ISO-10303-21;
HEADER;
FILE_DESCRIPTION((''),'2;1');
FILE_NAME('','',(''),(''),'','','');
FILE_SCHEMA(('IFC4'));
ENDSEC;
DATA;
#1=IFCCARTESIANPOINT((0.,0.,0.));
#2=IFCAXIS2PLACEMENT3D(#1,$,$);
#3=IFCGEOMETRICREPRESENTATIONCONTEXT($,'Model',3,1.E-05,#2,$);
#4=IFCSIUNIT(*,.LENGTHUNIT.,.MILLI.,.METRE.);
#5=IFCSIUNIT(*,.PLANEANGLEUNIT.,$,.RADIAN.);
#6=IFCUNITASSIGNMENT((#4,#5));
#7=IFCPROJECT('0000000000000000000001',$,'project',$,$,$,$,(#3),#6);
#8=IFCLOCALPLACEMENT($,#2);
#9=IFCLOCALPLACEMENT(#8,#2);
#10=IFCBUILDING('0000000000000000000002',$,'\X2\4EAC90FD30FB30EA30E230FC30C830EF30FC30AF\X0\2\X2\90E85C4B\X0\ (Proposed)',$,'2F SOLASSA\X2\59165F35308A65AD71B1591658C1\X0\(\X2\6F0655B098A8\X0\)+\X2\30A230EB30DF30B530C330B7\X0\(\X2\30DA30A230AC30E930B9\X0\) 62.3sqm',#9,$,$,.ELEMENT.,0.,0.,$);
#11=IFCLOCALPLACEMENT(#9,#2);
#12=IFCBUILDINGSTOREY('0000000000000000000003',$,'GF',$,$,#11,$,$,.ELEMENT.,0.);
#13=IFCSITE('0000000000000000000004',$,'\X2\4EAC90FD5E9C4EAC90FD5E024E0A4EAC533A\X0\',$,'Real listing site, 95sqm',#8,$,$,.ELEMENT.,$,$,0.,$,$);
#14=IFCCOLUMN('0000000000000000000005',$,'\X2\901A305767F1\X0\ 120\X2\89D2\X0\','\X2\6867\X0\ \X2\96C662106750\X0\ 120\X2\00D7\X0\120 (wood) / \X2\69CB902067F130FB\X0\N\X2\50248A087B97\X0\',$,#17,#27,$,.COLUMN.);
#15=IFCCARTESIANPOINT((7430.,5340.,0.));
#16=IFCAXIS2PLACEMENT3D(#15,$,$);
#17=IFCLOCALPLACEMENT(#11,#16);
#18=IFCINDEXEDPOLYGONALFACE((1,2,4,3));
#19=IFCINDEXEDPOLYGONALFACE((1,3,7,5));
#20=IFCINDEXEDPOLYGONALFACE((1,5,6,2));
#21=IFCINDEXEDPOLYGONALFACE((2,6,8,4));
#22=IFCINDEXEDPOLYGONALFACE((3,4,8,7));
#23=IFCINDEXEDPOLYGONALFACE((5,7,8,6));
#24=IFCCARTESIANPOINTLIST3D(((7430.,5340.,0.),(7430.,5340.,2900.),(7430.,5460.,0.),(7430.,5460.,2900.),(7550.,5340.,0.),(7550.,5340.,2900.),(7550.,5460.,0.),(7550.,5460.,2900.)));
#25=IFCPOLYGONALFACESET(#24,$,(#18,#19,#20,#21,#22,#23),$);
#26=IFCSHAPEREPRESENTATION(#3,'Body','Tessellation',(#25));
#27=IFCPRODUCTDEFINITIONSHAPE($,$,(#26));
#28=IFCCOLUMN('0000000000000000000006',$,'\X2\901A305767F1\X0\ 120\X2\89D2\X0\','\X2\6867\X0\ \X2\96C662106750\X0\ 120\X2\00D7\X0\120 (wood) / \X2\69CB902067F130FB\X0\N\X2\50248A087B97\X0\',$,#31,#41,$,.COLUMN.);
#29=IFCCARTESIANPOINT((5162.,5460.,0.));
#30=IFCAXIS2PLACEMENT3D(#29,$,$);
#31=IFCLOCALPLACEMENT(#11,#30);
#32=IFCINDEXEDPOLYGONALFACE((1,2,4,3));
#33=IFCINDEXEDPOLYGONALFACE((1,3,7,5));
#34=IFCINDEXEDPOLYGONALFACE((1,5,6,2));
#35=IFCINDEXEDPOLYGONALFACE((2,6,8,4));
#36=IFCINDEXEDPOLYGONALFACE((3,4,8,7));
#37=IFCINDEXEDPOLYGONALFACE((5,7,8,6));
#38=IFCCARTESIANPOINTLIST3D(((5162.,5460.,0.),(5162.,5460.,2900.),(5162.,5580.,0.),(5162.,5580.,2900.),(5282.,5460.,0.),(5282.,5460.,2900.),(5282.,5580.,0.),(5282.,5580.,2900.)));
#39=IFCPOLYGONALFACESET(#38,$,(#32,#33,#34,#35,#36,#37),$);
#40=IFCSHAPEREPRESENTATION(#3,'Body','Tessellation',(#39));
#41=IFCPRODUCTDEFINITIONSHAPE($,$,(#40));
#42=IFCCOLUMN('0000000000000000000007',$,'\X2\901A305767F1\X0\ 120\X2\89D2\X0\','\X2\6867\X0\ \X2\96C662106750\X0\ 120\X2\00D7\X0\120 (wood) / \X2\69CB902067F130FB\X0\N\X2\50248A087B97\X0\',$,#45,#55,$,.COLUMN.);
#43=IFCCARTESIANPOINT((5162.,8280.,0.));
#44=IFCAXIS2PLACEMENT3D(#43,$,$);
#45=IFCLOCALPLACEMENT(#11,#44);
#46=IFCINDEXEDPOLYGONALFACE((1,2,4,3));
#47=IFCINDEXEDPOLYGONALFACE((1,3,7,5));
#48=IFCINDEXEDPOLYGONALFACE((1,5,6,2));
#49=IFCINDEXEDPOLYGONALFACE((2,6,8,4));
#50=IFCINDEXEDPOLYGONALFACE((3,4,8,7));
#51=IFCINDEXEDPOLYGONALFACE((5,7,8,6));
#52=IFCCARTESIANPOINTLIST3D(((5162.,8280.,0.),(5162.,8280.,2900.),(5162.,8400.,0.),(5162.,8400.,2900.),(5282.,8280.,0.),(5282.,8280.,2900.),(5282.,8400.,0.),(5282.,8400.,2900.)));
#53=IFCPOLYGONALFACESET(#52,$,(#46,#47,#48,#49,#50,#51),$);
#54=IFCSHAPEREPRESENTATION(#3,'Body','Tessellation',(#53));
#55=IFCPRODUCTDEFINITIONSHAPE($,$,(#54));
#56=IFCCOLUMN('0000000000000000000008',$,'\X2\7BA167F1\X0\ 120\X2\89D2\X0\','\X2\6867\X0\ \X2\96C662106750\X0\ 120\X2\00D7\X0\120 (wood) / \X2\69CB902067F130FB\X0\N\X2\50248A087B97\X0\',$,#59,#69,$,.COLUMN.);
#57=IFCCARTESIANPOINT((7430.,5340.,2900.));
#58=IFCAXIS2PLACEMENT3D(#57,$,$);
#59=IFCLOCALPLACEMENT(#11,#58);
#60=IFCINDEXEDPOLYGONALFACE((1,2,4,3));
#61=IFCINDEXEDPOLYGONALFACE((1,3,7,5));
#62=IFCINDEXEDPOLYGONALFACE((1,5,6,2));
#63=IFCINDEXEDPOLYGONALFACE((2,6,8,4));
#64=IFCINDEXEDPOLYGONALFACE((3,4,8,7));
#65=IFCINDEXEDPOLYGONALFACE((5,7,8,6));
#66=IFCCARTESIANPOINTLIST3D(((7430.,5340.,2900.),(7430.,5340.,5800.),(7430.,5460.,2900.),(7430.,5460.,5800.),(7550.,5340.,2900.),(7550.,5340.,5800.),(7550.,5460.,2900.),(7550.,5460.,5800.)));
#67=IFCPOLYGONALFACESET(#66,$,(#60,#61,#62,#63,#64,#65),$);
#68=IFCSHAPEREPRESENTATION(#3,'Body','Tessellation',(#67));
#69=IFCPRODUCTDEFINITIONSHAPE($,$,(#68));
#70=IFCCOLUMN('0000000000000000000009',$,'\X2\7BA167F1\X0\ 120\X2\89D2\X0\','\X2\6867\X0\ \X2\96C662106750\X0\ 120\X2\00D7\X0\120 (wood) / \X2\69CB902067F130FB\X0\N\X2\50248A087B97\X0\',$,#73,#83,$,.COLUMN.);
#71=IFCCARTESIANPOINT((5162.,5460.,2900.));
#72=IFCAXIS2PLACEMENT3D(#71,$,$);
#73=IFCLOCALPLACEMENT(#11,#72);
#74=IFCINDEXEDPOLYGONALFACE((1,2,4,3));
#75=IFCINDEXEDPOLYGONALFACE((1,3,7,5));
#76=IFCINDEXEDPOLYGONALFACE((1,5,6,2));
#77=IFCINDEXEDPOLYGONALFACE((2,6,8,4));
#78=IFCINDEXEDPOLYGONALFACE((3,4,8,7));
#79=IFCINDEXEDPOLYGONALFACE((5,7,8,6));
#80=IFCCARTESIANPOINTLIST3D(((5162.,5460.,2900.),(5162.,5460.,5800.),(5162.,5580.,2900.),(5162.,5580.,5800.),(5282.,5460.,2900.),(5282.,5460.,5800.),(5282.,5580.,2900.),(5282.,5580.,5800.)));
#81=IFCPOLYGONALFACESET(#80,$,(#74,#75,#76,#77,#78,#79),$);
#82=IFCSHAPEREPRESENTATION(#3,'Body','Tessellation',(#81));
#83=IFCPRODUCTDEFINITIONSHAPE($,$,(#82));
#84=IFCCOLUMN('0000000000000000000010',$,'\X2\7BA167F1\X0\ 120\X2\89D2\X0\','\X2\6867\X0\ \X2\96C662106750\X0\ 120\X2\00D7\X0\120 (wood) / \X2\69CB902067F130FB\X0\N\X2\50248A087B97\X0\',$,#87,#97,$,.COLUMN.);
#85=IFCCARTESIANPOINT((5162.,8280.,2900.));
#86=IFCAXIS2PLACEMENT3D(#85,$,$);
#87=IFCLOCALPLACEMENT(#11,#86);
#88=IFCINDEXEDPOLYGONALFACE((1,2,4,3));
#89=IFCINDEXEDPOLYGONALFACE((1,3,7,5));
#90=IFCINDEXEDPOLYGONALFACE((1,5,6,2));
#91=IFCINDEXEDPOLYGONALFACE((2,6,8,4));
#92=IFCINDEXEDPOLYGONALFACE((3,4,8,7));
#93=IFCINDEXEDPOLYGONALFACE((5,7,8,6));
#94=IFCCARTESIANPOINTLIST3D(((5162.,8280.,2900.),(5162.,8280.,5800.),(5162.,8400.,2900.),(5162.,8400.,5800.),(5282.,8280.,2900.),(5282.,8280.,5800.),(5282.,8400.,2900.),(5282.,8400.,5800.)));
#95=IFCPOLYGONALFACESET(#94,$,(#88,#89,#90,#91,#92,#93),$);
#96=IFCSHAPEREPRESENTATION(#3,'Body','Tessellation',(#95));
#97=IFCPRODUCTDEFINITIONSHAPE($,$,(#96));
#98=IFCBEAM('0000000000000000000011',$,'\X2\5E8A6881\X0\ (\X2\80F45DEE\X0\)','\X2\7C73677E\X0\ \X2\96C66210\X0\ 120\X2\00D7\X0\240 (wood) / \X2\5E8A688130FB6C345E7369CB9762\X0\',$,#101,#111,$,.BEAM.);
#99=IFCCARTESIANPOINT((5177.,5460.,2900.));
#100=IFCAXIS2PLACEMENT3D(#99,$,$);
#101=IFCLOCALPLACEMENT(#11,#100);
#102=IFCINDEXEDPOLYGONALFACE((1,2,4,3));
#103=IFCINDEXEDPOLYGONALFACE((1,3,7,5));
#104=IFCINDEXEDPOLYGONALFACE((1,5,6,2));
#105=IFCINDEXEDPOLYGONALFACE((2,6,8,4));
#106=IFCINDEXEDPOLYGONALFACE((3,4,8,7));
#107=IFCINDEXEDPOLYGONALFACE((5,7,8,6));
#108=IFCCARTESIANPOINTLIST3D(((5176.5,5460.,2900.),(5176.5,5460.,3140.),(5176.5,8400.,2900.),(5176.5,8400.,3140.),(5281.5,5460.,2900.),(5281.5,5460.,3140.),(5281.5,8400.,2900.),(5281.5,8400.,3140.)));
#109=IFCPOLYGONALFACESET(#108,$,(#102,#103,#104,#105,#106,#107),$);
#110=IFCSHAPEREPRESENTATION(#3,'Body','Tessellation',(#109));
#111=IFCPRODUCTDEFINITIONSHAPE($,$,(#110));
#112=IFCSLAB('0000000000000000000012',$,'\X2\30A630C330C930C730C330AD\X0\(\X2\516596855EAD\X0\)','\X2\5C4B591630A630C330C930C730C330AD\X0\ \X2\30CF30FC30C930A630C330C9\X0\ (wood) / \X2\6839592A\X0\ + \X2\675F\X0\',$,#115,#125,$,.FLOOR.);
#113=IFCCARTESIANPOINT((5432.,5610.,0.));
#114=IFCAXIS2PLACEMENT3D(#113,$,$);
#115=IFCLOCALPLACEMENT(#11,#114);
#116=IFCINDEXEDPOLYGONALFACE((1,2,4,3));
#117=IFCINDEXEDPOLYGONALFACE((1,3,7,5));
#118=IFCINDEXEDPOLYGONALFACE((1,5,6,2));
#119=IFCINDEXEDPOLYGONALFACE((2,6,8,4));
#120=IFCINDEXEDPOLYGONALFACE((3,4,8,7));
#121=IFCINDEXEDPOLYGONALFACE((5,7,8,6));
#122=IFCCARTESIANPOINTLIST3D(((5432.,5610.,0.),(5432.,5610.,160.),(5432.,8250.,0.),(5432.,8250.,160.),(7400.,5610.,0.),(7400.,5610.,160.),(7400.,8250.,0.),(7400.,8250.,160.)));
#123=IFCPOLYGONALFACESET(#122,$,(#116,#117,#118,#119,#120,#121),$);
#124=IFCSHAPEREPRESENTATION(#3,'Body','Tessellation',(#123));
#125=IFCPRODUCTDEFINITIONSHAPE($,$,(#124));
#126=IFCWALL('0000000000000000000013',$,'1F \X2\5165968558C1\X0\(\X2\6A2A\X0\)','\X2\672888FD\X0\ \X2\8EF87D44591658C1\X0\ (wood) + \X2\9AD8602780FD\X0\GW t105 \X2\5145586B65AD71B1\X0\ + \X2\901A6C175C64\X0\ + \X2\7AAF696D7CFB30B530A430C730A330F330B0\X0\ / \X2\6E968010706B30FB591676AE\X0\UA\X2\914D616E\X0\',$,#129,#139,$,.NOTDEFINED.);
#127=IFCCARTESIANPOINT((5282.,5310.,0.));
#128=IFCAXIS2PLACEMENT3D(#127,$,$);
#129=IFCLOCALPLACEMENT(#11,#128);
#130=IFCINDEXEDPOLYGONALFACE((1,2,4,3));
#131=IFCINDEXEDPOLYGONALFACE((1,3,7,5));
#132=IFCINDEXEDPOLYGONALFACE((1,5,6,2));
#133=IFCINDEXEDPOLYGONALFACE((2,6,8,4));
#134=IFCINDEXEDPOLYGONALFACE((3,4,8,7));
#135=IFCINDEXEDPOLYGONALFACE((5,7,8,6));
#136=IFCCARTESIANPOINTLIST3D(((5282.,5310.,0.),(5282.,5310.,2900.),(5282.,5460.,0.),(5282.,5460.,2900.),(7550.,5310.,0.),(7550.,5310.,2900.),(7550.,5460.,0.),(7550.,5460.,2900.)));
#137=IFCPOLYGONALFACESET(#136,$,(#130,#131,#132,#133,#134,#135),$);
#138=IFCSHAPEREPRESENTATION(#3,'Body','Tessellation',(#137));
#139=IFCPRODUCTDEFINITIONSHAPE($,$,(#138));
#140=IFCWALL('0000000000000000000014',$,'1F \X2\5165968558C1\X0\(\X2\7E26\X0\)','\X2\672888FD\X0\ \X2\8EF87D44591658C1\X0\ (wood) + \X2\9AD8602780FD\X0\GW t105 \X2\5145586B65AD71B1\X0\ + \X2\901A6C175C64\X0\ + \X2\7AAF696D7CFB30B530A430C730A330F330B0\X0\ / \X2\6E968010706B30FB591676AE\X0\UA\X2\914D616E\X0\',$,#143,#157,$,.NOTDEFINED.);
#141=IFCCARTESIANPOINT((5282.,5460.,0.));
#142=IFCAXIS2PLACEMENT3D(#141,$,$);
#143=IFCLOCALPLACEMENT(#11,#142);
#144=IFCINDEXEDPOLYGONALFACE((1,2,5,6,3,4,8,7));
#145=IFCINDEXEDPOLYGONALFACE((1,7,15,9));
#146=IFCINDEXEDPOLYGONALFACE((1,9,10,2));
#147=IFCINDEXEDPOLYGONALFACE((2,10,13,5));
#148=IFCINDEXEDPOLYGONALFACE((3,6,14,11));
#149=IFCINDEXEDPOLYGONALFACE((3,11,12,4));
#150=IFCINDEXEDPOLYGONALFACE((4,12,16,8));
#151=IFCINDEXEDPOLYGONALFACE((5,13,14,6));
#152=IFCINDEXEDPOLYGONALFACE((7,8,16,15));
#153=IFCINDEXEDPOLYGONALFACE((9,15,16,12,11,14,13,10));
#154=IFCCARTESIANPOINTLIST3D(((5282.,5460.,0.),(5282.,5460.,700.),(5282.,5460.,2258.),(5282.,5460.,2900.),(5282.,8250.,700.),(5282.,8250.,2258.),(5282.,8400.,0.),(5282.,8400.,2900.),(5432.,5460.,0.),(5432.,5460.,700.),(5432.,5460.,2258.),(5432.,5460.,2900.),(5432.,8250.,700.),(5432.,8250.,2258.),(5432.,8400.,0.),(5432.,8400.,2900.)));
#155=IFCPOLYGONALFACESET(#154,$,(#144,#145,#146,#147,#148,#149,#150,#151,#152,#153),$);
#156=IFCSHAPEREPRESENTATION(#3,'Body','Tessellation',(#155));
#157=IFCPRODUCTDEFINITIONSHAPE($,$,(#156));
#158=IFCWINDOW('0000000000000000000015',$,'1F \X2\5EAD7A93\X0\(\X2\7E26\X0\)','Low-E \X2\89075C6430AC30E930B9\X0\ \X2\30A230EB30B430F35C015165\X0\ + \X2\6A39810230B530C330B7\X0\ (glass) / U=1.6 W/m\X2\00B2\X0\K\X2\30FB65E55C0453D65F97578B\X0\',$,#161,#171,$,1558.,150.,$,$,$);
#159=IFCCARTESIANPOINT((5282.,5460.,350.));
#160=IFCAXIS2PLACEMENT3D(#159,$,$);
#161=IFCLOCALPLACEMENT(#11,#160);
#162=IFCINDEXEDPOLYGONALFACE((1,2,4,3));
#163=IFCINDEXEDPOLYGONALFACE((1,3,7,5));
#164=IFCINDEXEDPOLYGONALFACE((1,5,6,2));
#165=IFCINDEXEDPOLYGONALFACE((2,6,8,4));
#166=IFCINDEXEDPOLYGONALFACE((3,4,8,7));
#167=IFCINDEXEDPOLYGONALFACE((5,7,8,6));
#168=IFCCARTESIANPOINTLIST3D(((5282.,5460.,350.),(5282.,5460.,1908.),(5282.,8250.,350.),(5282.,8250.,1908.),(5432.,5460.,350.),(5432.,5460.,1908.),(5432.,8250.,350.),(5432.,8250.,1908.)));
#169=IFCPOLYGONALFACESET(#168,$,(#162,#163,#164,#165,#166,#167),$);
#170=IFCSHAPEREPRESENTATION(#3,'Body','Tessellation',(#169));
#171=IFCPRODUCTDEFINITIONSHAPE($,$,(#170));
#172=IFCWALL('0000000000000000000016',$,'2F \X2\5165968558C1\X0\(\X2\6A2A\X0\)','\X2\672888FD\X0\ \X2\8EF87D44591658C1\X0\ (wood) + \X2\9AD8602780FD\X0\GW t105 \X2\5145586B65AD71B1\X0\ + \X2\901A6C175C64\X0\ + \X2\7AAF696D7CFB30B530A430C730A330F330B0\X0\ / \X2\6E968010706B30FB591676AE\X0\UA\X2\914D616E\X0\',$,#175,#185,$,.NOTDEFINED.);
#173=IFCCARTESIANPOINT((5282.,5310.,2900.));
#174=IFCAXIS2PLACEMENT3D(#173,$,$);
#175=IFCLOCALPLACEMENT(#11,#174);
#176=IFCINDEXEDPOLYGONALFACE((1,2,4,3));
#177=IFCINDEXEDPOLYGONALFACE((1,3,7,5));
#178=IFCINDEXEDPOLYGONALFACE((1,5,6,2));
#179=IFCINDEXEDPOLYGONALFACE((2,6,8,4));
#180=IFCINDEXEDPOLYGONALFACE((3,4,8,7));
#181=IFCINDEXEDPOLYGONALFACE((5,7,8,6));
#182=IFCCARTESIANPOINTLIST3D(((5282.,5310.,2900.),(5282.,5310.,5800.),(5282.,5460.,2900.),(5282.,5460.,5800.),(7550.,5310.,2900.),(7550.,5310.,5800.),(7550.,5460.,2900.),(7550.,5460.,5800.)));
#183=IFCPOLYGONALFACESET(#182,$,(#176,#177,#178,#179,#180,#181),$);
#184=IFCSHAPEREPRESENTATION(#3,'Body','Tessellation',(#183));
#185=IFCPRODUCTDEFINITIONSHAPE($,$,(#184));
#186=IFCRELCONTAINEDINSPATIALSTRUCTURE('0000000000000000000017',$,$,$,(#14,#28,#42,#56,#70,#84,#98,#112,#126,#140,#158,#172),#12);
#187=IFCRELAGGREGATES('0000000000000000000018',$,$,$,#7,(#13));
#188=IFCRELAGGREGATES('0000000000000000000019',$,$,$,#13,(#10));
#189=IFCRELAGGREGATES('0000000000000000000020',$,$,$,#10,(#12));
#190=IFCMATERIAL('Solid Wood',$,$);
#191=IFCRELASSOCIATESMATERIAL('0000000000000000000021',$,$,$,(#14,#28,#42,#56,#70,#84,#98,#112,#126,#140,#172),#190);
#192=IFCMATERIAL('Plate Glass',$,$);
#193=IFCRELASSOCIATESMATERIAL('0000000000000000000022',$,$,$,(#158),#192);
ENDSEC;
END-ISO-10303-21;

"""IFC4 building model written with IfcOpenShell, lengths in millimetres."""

from ifc_helpers import new_model, si_unit, frame, frame_2d, origin, place, context, project, spatial, rectangle, extrude, material, element, fill, save


model = new_model("IFC4")

# Units and contexts
model_context = context("Model", 3, precision=1e-05, world=origin())
ifc_project = project(units=[si_unit("LENGTHUNIT", "METRE", prefix="MILLI"), si_unit("PLANEANGLEUNIT", "RADIAN")], contexts=[model_context])

# Site, building, storey
site_placement = place(None, origin())
site = spatial("IfcSite", under=ifc_project, at=site_placement, Name="京都府京都市上京区", ObjectType="Real listing site, 95sqm", CompositionType="ELEMENT", RefElevation=0.0)
building_placement = place(site_placement, origin())
building = spatial("IfcBuilding", under=site, at=building_placement, Name="京都・リモートワーク2部屋 (Proposed)", ObjectType="2F SOLASSA外張り断熱外壁(漆喰風)+アルミサッシ(ペアガラス) 62.3sqm", CompositionType="ELEMENT", ElevationOfRefHeight=0.0, ElevationOfTerrain=0.0)
storey_placement = place(building_placement, origin())
storey = spatial("IfcBuildingStorey", under=building, at=storey_placement, Name="GF", CompositionType="ELEMENT", Elevation=0.0)

# Columns
ifc_material_1 = material(Name="Solid Wood")
column_1_placement = place(storey_placement, frame((7430.0, 5340.0, 0.0)))
element("IfcColumn", 1, at=column_1_placement, inside=storey, material=ifc_material_1, Name="通し柱 120角", Description="桧 集成材 120×120 (wood) / 構造柱・N値計算", PredefinedType="COLUMN", context=model_context, shape_type="SweptSolid", body=[
    extrude(rectangle(XDim=120.0, YDim=120.0, at=frame_2d((60.0, 60.0))), frame((7430.0, 5340.0, 0.0)), (0.0, 0.0, 1.0), 2900.0),
])
column_2_placement = place(storey_placement, frame((5162.0, 5460.0, 0.0)))
element("IfcColumn", 2, at=column_2_placement, inside=storey, material=ifc_material_1, Name="通し柱 120角", Description="桧 集成材 120×120 (wood) / 構造柱・N値計算", PredefinedType="COLUMN", context=model_context, shape_type="SweptSolid", body=[
    extrude(rectangle(XDim=120.0, YDim=120.0, at=frame_2d((60.0, 60.0))), frame((5162.0, 5460.0, 0.0)), (0.0, 0.0, 1.0), 2900.0),
])
column_3_placement = place(storey_placement, frame((5162.0, 8280.0, 0.0)))
element("IfcColumn", 3, at=column_3_placement, inside=storey, material=ifc_material_1, Name="通し柱 120角", Description="桧 集成材 120×120 (wood) / 構造柱・N値計算", PredefinedType="COLUMN", context=model_context, shape_type="SweptSolid", body=[
    extrude(rectangle(XDim=120.0, YDim=120.0, at=frame_2d((60.0, 60.0))), frame((5162.0, 8280.0, 0.0)), (0.0, 0.0, 1.0), 2900.0),
])
column_4_placement = place(storey_placement, frame((7430.0, 5340.0, 2900.0)))
element("IfcColumn", 4, at=column_4_placement, inside=storey, material=ifc_material_1, Name="管柱 120角", Description="桧 集成材 120×120 (wood) / 構造柱・N値計算", PredefinedType="COLUMN", context=model_context, shape_type="SweptSolid", body=[
    extrude(rectangle(XDim=120.0, YDim=120.0, at=frame_2d((60.0, 60.0))), frame((7430.0, 5340.0, 2900.0)), (0.0, 0.0, 1.0), 2900.0),
])
column_5_placement = place(storey_placement, frame((5162.0, 5460.0, 2900.0)))
element("IfcColumn", 5, at=column_5_placement, inside=storey, material=ifc_material_1, Name="管柱 120角", Description="桧 集成材 120×120 (wood) / 構造柱・N値計算", PredefinedType="COLUMN", context=model_context, shape_type="SweptSolid", body=[
    extrude(rectangle(XDim=120.0, YDim=120.0, at=frame_2d((60.0, 60.0))), frame((5162.0, 5460.0, 2900.0)), (0.0, 0.0, 1.0), 2900.0),
])
column_6_placement = place(storey_placement, frame((5162.0, 8280.0, 2900.0)))
element("IfcColumn", 6, at=column_6_placement, inside=storey, material=ifc_material_1, Name="管柱 120角", Description="桧 集成材 120×120 (wood) / 構造柱・N値計算", PredefinedType="COLUMN", context=model_context, shape_type="SweptSolid", body=[
    extrude(rectangle(XDim=120.0, YDim=120.0, at=frame_2d((60.0, 60.0))), frame((5162.0, 8280.0, 2900.0)), (0.0, 0.0, 1.0), 2900.0),
])

# Beam
beam_1_placement = place(storey_placement, frame((5177.0, 5460.0, 2900.0)))
element("IfcBeam", 7, at=beam_1_placement, inside=storey, material=ifc_material_1, Name="床梁 (胴差)", Description="米松 集成 120×240 (wood) / 床梁・水平構面", PredefinedType="BEAM", context=model_context, shape_type="SweptSolid", body=[
    extrude(rectangle(XDim=105.0, YDim=2940.0, at=frame_2d((52.0, 1470.0))), frame((5177.0, 5460.0, 2900.0)), (0.0, 0.0, 1.0), 240.0),
])

# Slab
slab_placement = place(storey_placement, frame((5432.0, 5610.0, 0.0)))
element("IfcSlab", 8, at=slab_placement, inside=storey, material=ifc_material_1, Name="ウッドデッキ(入隅庭)", Description="屋外ウッドデッキ ハードウッド (wood) / 根太 + 束", PredefinedType="FLOOR", context=model_context, shape_type="SweptSolid", body=[
    extrude(rectangle(XDim=1968.0, YDim=2640.0, at=frame_2d((984.0, 1320.0))), frame((5432.0, 5610.0, 0.0)), (0.0, 0.0, 1.0), 160.0),
])

# Wall
wall_1_placement = place(storey_placement, frame((5282.0, 5310.0, 0.0)))
element("IfcWall", 9, at=wall_1_placement, inside=storey, material=ifc_material_1, Name="1F 入隅壁(横)", Description="木製 軸組外壁 (wood) + 高性能GW t105 充填断熱 + 通気層 + 窯業系サイディング / 準耐火・外皮UA配慮", PredefinedType="NOTDEFINED", context=model_context, shape_type="SweptSolid", body=[
    extrude(rectangle(XDim=2268.0, YDim=150.0, at=frame_2d((1134.0, 75.0))), frame((5282.0, 5310.0, 0.0)), (0.0, 0.0, 1.0), 2900.0),
])

# Wall, opening, window
wall_2_placement = place(storey_placement, frame((5282.0, 5460.0, 0.0)))
wall_2 = element("IfcWall", 10, at=wall_2_placement, inside=storey, material=ifc_material_1, Name="1F 入隅壁(縦)", Description="木製 軸組外壁 (wood) + 高性能GW t105 充填断熱 + 通気層 + 窯業系サイディング / 準耐火・外皮UA配慮", PredefinedType="NOTDEFINED", context=model_context, shape_type="SweptSolid", body=[
    extrude(rectangle(XDim=150.0, YDim=2940.0, at=frame_2d((75.0, 1470.0))), frame((5282.0, 5460.0, 0.0)), (0.0, 0.0, 1.0), 2900.0),
])
opening_1_placement = place(storey_placement, frame((5282.0, 5460.0, 350.0)))
opening_1 = element("IfcOpeningElement", 11, at=opening_1_placement, cuts=wall_2, PredefinedType="NOTDEFINED", context=model_context, shape_type="SweptSolid", body=[
    extrude(rectangle(XDim=150.0, YDim=2790.0, at=frame_2d((75.0, 1395.0))), frame((5282.0, 5460.0, 350.0)), (0.0, 0.0, 1.0), 1558.0),
])
ifc_material_2 = material(Name="Plate Glass")
window_1_placement = place(storey_placement, frame((5282.0, 5460.0, 350.0)))
window_1 = element("IfcWindow", 12, at=window_1_placement, inside=storey, material=ifc_material_2, Name="1F 庭窓(縦)", Description="Low-E 複層ガラス アルゴン封入 + 樹脂サッシ (glass) / U=1.6 W/m²K・日射取得型", OverallHeight=1558.0, OverallWidth=150.0, context=model_context, shape_type="SweptSolid", body=[
    extrude(rectangle(XDim=150.0, YDim=2790.0, at=frame_2d((75.0, 1395.0))), frame((5282.0, 5460.0, 350.0)), (0.0, 0.0, 1.0), 1558.0),
])
fill(opening_1, window_1)

# Wall
wall_3_placement = place(storey_placement, frame((5282.0, 5310.0, 2900.0)))
element("IfcWall", 13, at=wall_3_placement, inside=storey, material=ifc_material_1, Name="2F 入隅壁(横)", Description="木製 軸組外壁 (wood) + 高性能GW t105 充填断熱 + 通気層 + 窯業系サイディング / 準耐火・外皮UA配慮", PredefinedType="NOTDEFINED", context=model_context, shape_type="SweptSolid", body=[
    extrude(rectangle(XDim=2268.0, YDim=150.0, at=frame_2d((1134.0, 75.0))), frame((5282.0, 5310.0, 2900.0)), (0.0, 0.0, 1.0), 2900.0),
])

save(model, "model.ifc")
